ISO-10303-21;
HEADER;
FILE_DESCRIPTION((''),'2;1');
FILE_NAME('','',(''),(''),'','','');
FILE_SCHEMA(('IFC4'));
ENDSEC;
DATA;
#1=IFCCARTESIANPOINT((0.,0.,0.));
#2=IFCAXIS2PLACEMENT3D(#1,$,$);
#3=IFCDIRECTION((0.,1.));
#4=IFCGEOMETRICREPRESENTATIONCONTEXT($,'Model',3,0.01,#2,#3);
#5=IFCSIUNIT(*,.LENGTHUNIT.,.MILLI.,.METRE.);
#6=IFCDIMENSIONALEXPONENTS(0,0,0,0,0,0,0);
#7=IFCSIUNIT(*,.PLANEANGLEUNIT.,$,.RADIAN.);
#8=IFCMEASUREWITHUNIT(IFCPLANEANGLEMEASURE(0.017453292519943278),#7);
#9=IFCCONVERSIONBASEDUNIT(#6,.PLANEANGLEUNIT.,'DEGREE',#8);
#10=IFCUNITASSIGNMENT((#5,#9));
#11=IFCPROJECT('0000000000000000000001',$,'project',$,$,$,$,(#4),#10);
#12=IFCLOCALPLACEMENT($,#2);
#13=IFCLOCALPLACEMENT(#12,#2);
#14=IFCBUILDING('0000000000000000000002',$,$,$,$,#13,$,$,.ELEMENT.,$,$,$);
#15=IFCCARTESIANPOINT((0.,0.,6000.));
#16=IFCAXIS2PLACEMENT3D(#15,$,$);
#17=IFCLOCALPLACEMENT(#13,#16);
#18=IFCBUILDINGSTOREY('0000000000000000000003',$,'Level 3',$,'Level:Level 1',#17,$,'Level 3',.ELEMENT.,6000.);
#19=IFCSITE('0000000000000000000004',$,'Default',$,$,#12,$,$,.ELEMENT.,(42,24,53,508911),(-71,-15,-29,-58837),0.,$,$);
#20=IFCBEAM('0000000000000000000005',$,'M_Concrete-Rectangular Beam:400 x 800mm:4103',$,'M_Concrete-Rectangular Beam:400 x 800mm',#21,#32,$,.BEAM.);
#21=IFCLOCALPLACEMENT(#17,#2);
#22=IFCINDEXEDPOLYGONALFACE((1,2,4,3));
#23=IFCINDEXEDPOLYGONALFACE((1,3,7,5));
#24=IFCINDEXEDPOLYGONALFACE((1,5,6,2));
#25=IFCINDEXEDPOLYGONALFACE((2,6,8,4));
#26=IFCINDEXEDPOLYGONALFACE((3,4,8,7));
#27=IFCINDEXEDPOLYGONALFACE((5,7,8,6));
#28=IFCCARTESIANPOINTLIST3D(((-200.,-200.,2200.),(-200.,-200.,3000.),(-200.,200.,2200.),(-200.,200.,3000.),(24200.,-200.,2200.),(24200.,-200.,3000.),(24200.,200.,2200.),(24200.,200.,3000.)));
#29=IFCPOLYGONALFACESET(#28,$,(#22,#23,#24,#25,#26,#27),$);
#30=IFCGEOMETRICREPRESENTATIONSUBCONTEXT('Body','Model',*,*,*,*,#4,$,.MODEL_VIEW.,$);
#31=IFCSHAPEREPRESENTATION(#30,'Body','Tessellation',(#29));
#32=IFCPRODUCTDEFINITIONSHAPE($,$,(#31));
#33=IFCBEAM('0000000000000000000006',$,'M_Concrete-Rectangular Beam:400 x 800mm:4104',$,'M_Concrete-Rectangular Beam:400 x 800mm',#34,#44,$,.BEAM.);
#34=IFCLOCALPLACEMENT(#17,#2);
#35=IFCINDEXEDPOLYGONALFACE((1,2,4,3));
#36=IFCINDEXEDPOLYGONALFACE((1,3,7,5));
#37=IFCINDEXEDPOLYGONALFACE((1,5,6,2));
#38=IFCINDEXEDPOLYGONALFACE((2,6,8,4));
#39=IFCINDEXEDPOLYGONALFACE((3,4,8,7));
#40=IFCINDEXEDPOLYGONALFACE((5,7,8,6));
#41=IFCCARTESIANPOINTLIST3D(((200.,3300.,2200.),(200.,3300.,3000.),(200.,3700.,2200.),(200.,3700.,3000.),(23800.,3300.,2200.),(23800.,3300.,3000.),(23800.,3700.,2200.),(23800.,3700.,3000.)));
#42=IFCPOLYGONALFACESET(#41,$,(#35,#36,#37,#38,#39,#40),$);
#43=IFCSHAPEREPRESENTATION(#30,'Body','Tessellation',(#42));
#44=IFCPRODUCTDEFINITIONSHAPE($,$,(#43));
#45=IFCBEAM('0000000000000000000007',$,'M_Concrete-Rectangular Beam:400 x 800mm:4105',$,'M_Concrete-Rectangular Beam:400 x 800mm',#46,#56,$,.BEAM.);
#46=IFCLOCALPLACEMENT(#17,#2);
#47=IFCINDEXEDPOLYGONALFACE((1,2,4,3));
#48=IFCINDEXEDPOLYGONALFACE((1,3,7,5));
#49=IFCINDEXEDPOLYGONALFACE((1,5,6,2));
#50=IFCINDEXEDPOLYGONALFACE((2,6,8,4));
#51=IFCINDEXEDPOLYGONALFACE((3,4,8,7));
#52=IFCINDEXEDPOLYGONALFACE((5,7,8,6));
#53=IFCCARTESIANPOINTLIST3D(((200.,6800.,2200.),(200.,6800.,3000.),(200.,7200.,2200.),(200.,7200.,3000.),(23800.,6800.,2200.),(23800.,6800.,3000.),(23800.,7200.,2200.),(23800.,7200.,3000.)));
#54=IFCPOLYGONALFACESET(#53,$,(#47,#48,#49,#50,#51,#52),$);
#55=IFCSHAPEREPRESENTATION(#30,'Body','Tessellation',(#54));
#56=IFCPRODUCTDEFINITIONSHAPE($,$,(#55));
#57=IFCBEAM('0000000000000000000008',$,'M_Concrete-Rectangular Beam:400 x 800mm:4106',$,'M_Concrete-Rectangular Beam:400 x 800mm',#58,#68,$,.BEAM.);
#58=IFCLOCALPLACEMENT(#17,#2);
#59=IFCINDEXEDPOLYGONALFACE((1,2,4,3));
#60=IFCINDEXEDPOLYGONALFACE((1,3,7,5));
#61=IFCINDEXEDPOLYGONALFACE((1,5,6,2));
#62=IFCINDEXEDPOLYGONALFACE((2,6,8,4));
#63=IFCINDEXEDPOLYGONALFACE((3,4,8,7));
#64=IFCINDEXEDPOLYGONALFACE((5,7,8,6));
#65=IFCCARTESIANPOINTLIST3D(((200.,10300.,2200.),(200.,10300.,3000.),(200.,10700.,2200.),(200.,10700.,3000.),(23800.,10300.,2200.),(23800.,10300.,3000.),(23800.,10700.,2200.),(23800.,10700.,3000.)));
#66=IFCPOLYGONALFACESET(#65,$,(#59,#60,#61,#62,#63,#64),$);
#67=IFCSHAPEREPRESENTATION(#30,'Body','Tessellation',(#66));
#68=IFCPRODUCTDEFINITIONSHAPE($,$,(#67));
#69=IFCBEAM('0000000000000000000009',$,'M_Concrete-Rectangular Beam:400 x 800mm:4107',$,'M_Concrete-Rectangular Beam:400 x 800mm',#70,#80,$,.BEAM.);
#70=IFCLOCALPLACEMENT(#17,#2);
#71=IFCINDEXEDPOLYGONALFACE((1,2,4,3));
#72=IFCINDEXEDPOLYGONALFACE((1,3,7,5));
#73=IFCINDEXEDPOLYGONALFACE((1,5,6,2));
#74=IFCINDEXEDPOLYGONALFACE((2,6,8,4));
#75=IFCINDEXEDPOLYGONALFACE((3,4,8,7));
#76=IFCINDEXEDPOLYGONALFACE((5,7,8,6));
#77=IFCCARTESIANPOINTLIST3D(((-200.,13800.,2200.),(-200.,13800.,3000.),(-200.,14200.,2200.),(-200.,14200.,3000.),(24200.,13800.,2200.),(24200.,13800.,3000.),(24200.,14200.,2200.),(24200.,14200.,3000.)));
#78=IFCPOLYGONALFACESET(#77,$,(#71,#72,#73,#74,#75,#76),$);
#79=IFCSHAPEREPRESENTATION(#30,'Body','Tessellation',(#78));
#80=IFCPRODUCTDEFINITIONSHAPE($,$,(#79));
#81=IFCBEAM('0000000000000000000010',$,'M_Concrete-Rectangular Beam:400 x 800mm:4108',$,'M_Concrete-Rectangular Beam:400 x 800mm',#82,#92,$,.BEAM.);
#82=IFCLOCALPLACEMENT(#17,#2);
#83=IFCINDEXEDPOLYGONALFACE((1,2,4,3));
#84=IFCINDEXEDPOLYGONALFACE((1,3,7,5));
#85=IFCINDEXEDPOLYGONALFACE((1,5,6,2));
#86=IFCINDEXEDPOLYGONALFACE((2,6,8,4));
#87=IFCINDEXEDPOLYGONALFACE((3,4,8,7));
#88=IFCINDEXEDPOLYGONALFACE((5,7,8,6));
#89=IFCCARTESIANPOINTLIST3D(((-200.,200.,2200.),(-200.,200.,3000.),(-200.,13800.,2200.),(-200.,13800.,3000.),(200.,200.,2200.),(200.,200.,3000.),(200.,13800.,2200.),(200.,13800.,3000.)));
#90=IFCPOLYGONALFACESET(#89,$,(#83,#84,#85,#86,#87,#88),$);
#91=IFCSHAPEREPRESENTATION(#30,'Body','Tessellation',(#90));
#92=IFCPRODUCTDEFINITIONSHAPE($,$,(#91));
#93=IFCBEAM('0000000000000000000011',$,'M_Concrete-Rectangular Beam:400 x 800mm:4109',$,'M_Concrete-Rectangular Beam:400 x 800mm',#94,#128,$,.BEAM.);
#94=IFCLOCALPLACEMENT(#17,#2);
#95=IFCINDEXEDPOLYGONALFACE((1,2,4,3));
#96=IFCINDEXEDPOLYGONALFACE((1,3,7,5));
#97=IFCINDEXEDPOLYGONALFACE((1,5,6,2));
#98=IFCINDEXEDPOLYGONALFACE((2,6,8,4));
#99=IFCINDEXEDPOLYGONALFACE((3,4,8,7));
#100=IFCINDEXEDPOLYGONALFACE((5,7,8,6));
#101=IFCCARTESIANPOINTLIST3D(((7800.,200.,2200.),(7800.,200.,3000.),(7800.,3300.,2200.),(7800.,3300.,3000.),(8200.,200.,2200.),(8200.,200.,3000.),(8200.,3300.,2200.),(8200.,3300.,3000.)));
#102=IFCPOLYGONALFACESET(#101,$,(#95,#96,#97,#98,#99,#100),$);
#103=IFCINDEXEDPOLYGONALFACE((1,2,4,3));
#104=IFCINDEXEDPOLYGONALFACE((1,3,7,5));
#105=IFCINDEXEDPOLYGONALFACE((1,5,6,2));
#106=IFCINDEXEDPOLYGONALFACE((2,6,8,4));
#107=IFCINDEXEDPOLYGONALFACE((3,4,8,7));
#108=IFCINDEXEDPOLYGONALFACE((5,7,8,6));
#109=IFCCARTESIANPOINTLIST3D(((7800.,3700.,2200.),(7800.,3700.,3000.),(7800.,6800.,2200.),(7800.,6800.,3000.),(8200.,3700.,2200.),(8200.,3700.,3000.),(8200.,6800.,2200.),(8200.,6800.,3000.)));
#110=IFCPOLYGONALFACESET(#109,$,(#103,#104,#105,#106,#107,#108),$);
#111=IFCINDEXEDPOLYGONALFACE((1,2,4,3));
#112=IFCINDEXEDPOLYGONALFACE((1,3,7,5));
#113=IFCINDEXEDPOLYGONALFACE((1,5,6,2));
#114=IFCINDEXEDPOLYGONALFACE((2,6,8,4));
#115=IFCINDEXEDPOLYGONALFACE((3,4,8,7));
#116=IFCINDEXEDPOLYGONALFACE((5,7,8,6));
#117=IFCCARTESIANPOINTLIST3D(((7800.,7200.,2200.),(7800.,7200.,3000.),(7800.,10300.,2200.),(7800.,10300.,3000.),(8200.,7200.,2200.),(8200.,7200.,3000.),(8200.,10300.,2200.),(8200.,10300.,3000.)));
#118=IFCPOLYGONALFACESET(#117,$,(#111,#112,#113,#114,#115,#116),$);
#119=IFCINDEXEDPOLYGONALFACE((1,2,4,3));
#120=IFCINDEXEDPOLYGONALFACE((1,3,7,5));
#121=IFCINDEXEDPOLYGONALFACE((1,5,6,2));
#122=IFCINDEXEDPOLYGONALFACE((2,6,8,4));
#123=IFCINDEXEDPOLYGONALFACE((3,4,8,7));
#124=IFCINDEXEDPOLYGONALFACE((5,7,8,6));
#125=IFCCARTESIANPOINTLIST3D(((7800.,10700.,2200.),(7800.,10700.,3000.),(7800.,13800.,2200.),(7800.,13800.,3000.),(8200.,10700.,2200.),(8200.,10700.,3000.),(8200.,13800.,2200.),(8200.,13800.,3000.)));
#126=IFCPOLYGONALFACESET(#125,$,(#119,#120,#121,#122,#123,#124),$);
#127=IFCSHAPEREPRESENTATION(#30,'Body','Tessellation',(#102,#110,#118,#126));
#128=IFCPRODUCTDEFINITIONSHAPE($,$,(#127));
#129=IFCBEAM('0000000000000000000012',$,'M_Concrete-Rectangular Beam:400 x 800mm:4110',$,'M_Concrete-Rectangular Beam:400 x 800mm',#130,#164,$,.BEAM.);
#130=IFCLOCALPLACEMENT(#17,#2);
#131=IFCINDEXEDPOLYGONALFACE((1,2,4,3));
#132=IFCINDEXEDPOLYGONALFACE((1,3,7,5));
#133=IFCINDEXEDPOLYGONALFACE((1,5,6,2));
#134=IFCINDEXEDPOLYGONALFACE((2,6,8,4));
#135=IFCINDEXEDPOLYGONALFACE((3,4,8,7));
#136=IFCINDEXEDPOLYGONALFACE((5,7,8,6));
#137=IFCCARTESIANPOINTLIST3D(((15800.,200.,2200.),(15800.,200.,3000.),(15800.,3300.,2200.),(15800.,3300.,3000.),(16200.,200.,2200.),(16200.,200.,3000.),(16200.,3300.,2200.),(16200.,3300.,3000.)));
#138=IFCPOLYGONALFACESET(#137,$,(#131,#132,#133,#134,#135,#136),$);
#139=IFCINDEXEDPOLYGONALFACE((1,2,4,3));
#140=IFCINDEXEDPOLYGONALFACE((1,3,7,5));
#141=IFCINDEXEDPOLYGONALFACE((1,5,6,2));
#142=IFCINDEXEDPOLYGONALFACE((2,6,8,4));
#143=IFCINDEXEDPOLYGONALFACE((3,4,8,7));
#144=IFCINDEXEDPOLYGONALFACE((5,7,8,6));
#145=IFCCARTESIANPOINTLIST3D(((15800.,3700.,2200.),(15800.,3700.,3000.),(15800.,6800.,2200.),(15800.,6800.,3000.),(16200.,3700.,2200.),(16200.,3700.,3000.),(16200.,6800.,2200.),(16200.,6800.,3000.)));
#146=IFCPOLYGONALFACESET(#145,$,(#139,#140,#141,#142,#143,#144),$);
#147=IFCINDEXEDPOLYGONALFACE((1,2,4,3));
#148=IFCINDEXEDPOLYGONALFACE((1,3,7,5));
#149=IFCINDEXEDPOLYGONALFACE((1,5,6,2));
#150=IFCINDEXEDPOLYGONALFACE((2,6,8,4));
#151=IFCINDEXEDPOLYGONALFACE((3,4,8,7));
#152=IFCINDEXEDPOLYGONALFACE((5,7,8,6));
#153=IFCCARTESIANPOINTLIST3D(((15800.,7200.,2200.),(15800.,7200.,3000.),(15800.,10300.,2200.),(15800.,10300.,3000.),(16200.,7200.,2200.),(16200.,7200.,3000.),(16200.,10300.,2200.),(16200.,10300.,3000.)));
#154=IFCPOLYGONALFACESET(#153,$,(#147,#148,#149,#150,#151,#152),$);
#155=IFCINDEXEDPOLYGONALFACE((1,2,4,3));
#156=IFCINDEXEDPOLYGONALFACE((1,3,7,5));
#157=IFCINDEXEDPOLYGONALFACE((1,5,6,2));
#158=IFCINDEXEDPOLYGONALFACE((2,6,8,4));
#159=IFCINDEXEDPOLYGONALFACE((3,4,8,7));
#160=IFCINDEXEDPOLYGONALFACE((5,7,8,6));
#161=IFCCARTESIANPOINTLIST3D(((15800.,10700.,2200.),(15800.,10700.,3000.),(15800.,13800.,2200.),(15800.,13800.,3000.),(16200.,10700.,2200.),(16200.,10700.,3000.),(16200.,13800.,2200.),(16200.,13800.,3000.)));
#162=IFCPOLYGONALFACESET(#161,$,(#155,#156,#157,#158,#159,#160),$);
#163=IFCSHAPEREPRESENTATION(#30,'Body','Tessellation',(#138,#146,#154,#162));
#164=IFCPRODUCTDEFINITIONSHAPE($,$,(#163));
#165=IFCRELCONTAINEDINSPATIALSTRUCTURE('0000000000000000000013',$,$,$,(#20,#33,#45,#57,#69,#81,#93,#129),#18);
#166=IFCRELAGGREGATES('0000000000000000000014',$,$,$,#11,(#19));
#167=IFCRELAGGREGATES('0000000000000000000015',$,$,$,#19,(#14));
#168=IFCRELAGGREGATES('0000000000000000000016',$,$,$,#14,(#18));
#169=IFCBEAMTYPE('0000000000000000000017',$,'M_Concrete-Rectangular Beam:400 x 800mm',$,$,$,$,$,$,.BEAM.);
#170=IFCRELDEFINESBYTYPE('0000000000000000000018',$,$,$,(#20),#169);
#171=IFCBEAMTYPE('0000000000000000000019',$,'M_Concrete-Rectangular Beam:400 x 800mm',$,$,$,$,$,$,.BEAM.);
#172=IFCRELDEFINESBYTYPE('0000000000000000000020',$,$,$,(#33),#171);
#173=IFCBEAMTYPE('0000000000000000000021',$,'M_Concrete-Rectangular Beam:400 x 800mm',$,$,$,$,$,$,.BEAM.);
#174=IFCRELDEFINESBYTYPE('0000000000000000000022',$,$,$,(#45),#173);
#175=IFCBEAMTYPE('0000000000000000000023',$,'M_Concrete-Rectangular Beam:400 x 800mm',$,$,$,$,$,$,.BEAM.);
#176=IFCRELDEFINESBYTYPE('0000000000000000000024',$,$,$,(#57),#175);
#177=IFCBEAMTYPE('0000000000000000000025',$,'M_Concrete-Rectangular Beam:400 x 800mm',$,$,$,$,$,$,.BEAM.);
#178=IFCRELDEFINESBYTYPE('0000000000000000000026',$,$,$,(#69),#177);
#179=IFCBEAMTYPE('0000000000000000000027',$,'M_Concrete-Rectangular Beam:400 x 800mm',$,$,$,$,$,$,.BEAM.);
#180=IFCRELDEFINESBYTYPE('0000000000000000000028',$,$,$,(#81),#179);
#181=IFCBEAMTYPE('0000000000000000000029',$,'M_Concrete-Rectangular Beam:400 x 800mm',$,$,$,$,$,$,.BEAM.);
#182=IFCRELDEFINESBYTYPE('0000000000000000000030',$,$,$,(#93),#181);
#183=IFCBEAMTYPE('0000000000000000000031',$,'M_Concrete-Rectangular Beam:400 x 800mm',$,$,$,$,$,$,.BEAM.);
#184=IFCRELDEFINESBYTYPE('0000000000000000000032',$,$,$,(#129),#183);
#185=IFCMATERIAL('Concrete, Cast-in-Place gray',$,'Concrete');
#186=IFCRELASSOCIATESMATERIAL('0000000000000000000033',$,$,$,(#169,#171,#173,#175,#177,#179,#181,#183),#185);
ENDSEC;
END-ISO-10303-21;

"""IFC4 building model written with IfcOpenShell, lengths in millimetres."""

from ifc_helpers import new_model, entity, si_unit, converted_unit, direction, frame, frame_2d, origin, origin_2d_with_axis, place, context, subcontext, project, spatial, rectangle, extrude, source, transform, mapped, material, material_profile, profile_set, type_object, type_shapes, element, save


model = new_model("IFC4")

# Units and contexts
model_context = context("Model", 3, precision=0.01, world=origin(), true_north=direction((0.0, 1.0)))
body_context = subcontext(model_context, "Body", "Model", "MODEL_VIEW")
ifc_project = project(units=[si_unit("LENGTHUNIT", "METRE", prefix="MILLI"), converted_unit("PLANEANGLEUNIT", "DEGREE", entity("IfcPlaneAngleMeasure", 0.017453292519943278), si_unit("PLANEANGLEUNIT", "RADIAN"), dimensions=[0, 0, 0, 0, 0, 0, 0])], contexts=[model_context])

# Site, building, storey
site_placement = place(None, origin())
site = spatial("IfcSite", under=ifc_project, at=site_placement, Name="Default", CompositionType="ELEMENT", RefLatitude=(42, 24, 53, 508911), RefLongitude=(-71, -15, -29, -58837), RefElevation=0.0)
building_placement = place(site_placement, origin())
building = spatial("IfcBuilding", under=site, at=building_placement, CompositionType="ELEMENT")
storey_placement = place(building_placement, frame((0.0, 0.0, 6000.0)))
storey = spatial("IfcBuildingStorey", under=building, at=storey_placement, Name="Level 3", ObjectType="Level:Level 1", LongName="Level 3", CompositionType="ELEMENT", Elevation=6000.0)

# Beams
ifc_material_1 = material(Name="Concrete, Cast-in-Place gray", Category="Concrete")
ifc_material_profile = material_profile(ifc_material_1, rectangle(XDim=800.0, YDim=400.0, at=origin_2d_with_axis()), Name="400 x 800mm")
ifc_profile_set = profile_set([ifc_material_profile], Name="400 x 800mm")
beam_type_1 = type_object("IfcBeamType", Name="M_Concrete-Rectangular Beam:400 x 800mm", PredefinedType="BEAM", material=ifc_profile_set)
shared_shape_1 = source(origin(), body_context, "Body", "SweptSolid", [
    extrude(rectangle(XDim=800.0, YDim=400.0, at=origin_2d_with_axis()), frame((-200.0, 0.0, 8600.0), z_axis=(1.0, 0.0, 0.0), x_axis=(0.0, 0.0, -1.0)), (0.0, 0.0, 1.0), 24400.0),
])
type_shapes(beam_type_1, [shared_shape_1])
beam_1_placement = place(storey_placement, frame((0.0, 0.0, -6000.0)))
element("IfcBeam", 1, at=beam_1_placement, inside=storey, type_object=beam_type_1, Name="M_Concrete-Rectangular Beam:400 x 800mm:4103", ObjectType="M_Concrete-Rectangular Beam:400 x 800mm", PredefinedType="BEAM", context=body_context, shape_type="MappedRepresentation", body=[
    mapped(shared_shape_1, transform((0.0, 0.0, 0.0), scale=1.0)),
])
beam_type_2 = type_object("IfcBeamType", Name="M_Concrete-Rectangular Beam:400 x 800mm", PredefinedType="BEAM", material=ifc_profile_set)
shared_shape_2 = source(origin(), body_context, "Body", "SweptSolid", [
    extrude(rectangle(XDim=800.0, YDim=400.0, at=origin_2d_with_axis()), frame((200.0, 3500.0, 8600.0), z_axis=(1.0, 0.0, 0.0), x_axis=(0.0, 0.0, -1.0)), (0.0, 0.0, 1.0), 23600.0),
])
type_shapes(beam_type_2, [shared_shape_2])
beam_2_placement = place(storey_placement, frame((0.0, 0.0, -6000.0)))
element("IfcBeam", 2, at=beam_2_placement, inside=storey, type_object=beam_type_2, Name="M_Concrete-Rectangular Beam:400 x 800mm:4104", ObjectType="M_Concrete-Rectangular Beam:400 x 800mm", PredefinedType="BEAM", context=body_context, shape_type="MappedRepresentation", body=[
    mapped(shared_shape_2, transform((0.0, 0.0, 0.0), scale=1.0)),
])
beam_type_3 = type_object("IfcBeamType", Name="M_Concrete-Rectangular Beam:400 x 800mm", PredefinedType="BEAM", material=ifc_profile_set)
shared_shape_3 = source(origin(), body_context, "Body", "SweptSolid", [
    extrude(rectangle(XDim=800.0, YDim=400.0, at=frame_2d((0.0, 0.0), x_axis=(1.0, 0.0))), frame((200.0, 7000.0, 8600.0), z_axis=(1.0, 0.0, 0.0), x_axis=(0.0, 0.0, -1.0)), (0.0, 0.0, 1.0), 23600.0),
])
type_shapes(beam_type_3, [shared_shape_3])
beam_3_placement = place(storey_placement, frame((0.0, 0.0, -6000.0)))
element("IfcBeam", 3, at=beam_3_placement, inside=storey, type_object=beam_type_3, Name="M_Concrete-Rectangular Beam:400 x 800mm:4105", ObjectType="M_Concrete-Rectangular Beam:400 x 800mm", PredefinedType="BEAM", context=body_context, shape_type="MappedRepresentation", body=[
    mapped(shared_shape_3, transform((0.0, 0.0, 0.0), scale=1.0)),
])
beam_type_4 = type_object("IfcBeamType", Name="M_Concrete-Rectangular Beam:400 x 800mm", PredefinedType="BEAM", material=ifc_profile_set)
shared_shape_4 = source(origin(), body_context, "Body", "SweptSolid", [
    extrude(rectangle(XDim=800.0, YDim=400.0, at=frame_2d((0.0, 0.0), x_axis=(1.0, 0.0))), frame((200.0, 10500.0, 8600.0), z_axis=(1.0, 0.0, 0.0), x_axis=(0.0, 0.0, -1.0)), (0.0, 0.0, 1.0), 23600.0),
])
type_shapes(beam_type_4, [shared_shape_4])
beam_4_placement = place(storey_placement, frame((0.0, 0.0, -6000.0)))
element("IfcBeam", 4, at=beam_4_placement, inside=storey, type_object=beam_type_4, Name="M_Concrete-Rectangular Beam:400 x 800mm:4106", ObjectType="M_Concrete-Rectangular Beam:400 x 800mm", PredefinedType="BEAM", context=body_context, shape_type="MappedRepresentation", body=[
    mapped(shared_shape_4, transform((0.0, 0.0, 0.0), scale=1.0)),
])
beam_type_5 = type_object("IfcBeamType", Name="M_Concrete-Rectangular Beam:400 x 800mm", PredefinedType="BEAM", material=ifc_profile_set)
shared_shape_5 = source(origin(), body_context, "Body", "SweptSolid", [
    extrude(rectangle(XDim=800.0, YDim=400.0, at=origin_2d_with_axis()), frame((-200.0, 14000.0, 8600.0), z_axis=(1.0, 0.0, 0.0), x_axis=(0.0, 0.0, -1.0)), (0.0, 0.0, 1.0), 24400.0),
])
type_shapes(beam_type_5, [shared_shape_5])
beam_5_placement = place(storey_placement, frame((0.0, 0.0, -6000.0)))
element("IfcBeam", 5, at=beam_5_placement, inside=storey, type_object=beam_type_5, Name="M_Concrete-Rectangular Beam:400 x 800mm:4107", ObjectType="M_Concrete-Rectangular Beam:400 x 800mm", PredefinedType="BEAM", context=body_context, shape_type="MappedRepresentation", body=[
    mapped(shared_shape_5, transform((0.0, 0.0, 0.0), scale=1.0)),
])
beam_type_6 = type_object("IfcBeamType", Name="M_Concrete-Rectangular Beam:400 x 800mm", PredefinedType="BEAM", material=ifc_profile_set)
shared_shape_6 = source(origin(), body_context, "Body", "SweptSolid", [
    extrude(rectangle(XDim=800.0, YDim=400.0, at=frame_2d((0.0, 0.0), x_axis=(0.0, 1.0))), frame((0.0, 200.0, 8600.0), z_axis=(0.0, 1.0, 0.0), x_axis=(-1.0, 0.0, 0.0)), (0.0, 0.0, 1.0), 13600.0),
])
type_shapes(beam_type_6, [shared_shape_6])
beam_6_placement = place(storey_placement, frame((0.0, 0.0, -6000.0)))
element("IfcBeam", 6, at=beam_6_placement, inside=storey, type_object=beam_type_6, Name="M_Concrete-Rectangular Beam:400 x 800mm:4108", ObjectType="M_Concrete-Rectangular Beam:400 x 800mm", PredefinedType="BEAM", context=body_context, shape_type="MappedRepresentation", body=[
    mapped(shared_shape_6, transform((0.0, 0.0, 0.0), scale=1.0)),
])
beam_type_7 = type_object("IfcBeamType", Name="M_Concrete-Rectangular Beam:400 x 800mm", PredefinedType="BEAM", material=ifc_profile_set)
shared_shape_7 = source(origin(), body_context, "Body", "SweptSolid", [
    extrude(rectangle(XDim=800.0, YDim=400.0, at=frame_2d((0.0, 0.0), x_axis=(0.0, 1.0))), frame((8000.0, 200.0, 8600.0), z_axis=(0.0, 1.0, 0.0), x_axis=(-1.0, 0.0, 0.0)), (0.0, 0.0, 1.0), 3100.0),
    extrude(rectangle(XDim=800.0, YDim=400.0, at=frame_2d((0.0, 0.0), x_axis=(0.0, 1.0))), frame((8000.0, 3700.0, 8600.0), z_axis=(0.0, 1.0, 0.0), x_axis=(-1.0, 0.0, 0.0)), (0.0, 0.0, 1.0), 3100.0),
    extrude(rectangle(XDim=800.0, YDim=400.0, at=frame_2d((0.0, 0.0), x_axis=(0.0, 1.0))), frame((8000.0, 7200.0, 8600.0), z_axis=(0.0, 1.0, 0.0), x_axis=(-1.0, 0.0, 0.0)), (0.0, 0.0, 1.0), 3100.0),
    extrude(rectangle(XDim=800.0, YDim=400.0, at=frame_2d((0.0, 0.0), x_axis=(0.0, 1.0))), frame((8000.0, 10700.0, 8600.0), z_axis=(0.0, 1.0, 0.0), x_axis=(-1.0, 0.0, 0.0)), (0.0, 0.0, 1.0), 3100.0),
])
type_shapes(beam_type_7, [shared_shape_7])
beam_7_placement = place(storey_placement, frame((0.0, 0.0, -6000.0)))
element("IfcBeam", 7, at=beam_7_placement, inside=storey, type_object=beam_type_7, Name="M_Concrete-Rectangular Beam:400 x 800mm:4109", ObjectType="M_Concrete-Rectangular Beam:400 x 800mm", PredefinedType="BEAM", context=body_context, shape_type="MappedRepresentation", body=[
    mapped(shared_shape_7, transform((0.0, 0.0, 0.0), scale=1.0)),
])
beam_type_8 = type_object("IfcBeamType", Name="M_Concrete-Rectangular Beam:400 x 800mm", PredefinedType="BEAM", material=ifc_profile_set)
shared_shape_8 = source(origin(), body_context, "Body", "SweptSolid", [
    extrude(rectangle(XDim=800.0, YDim=400.0, at=frame_2d((0.0, 0.0), x_axis=(0.0, 1.0))), frame((16000.0, 200.0, 8600.0), z_axis=(0.0, 1.0, 0.0), x_axis=(-1.0, 0.0, 0.0)), (0.0, 0.0, 1.0), 3100.0),
    extrude(rectangle(XDim=800.0, YDim=400.0, at=frame_2d((0.0, 0.0), x_axis=(0.0, 1.0))), frame((16000.0, 3700.0, 8600.0), z_axis=(0.0, 1.0, 0.0), x_axis=(-1.0, 0.0, 0.0)), (0.0, 0.0, 1.0), 3100.0),
    extrude(rectangle(XDim=800.0, YDim=400.0, at=frame_2d((0.0, 0.0), x_axis=(0.0, 1.0))), frame((16000.0, 7200.0, 8600.0), z_axis=(0.0, 1.0, 0.0), x_axis=(-1.0, 0.0, 0.0)), (0.0, 0.0, 1.0), 3100.0),
    extrude(rectangle(XDim=800.0, YDim=400.0, at=frame_2d((0.0, 0.0), x_axis=(0.0, 1.0))), frame((16000.0, 10700.0, 8600.0), z_axis=(0.0, 1.0, 0.0), x_axis=(-1.0, 0.0, 0.0)), (0.0, 0.0, 1.0), 3100.0),
])
type_shapes(beam_type_8, [shared_shape_8])
beam_8_placement = place(storey_placement, frame((0.0, 0.0, -6000.0)))
element("IfcBeam", 8, at=beam_8_placement, inside=storey, type_object=beam_type_8, Name="M_Concrete-Rectangular Beam:400 x 800mm:4110", ObjectType="M_Concrete-Rectangular Beam:400 x 800mm", PredefinedType="BEAM", context=body_context, shape_type="MappedRepresentation", body=[
    mapped(shared_shape_8, transform((0.0, 0.0, 0.0), scale=1.0)),
])

save(model, "model.ifc")
